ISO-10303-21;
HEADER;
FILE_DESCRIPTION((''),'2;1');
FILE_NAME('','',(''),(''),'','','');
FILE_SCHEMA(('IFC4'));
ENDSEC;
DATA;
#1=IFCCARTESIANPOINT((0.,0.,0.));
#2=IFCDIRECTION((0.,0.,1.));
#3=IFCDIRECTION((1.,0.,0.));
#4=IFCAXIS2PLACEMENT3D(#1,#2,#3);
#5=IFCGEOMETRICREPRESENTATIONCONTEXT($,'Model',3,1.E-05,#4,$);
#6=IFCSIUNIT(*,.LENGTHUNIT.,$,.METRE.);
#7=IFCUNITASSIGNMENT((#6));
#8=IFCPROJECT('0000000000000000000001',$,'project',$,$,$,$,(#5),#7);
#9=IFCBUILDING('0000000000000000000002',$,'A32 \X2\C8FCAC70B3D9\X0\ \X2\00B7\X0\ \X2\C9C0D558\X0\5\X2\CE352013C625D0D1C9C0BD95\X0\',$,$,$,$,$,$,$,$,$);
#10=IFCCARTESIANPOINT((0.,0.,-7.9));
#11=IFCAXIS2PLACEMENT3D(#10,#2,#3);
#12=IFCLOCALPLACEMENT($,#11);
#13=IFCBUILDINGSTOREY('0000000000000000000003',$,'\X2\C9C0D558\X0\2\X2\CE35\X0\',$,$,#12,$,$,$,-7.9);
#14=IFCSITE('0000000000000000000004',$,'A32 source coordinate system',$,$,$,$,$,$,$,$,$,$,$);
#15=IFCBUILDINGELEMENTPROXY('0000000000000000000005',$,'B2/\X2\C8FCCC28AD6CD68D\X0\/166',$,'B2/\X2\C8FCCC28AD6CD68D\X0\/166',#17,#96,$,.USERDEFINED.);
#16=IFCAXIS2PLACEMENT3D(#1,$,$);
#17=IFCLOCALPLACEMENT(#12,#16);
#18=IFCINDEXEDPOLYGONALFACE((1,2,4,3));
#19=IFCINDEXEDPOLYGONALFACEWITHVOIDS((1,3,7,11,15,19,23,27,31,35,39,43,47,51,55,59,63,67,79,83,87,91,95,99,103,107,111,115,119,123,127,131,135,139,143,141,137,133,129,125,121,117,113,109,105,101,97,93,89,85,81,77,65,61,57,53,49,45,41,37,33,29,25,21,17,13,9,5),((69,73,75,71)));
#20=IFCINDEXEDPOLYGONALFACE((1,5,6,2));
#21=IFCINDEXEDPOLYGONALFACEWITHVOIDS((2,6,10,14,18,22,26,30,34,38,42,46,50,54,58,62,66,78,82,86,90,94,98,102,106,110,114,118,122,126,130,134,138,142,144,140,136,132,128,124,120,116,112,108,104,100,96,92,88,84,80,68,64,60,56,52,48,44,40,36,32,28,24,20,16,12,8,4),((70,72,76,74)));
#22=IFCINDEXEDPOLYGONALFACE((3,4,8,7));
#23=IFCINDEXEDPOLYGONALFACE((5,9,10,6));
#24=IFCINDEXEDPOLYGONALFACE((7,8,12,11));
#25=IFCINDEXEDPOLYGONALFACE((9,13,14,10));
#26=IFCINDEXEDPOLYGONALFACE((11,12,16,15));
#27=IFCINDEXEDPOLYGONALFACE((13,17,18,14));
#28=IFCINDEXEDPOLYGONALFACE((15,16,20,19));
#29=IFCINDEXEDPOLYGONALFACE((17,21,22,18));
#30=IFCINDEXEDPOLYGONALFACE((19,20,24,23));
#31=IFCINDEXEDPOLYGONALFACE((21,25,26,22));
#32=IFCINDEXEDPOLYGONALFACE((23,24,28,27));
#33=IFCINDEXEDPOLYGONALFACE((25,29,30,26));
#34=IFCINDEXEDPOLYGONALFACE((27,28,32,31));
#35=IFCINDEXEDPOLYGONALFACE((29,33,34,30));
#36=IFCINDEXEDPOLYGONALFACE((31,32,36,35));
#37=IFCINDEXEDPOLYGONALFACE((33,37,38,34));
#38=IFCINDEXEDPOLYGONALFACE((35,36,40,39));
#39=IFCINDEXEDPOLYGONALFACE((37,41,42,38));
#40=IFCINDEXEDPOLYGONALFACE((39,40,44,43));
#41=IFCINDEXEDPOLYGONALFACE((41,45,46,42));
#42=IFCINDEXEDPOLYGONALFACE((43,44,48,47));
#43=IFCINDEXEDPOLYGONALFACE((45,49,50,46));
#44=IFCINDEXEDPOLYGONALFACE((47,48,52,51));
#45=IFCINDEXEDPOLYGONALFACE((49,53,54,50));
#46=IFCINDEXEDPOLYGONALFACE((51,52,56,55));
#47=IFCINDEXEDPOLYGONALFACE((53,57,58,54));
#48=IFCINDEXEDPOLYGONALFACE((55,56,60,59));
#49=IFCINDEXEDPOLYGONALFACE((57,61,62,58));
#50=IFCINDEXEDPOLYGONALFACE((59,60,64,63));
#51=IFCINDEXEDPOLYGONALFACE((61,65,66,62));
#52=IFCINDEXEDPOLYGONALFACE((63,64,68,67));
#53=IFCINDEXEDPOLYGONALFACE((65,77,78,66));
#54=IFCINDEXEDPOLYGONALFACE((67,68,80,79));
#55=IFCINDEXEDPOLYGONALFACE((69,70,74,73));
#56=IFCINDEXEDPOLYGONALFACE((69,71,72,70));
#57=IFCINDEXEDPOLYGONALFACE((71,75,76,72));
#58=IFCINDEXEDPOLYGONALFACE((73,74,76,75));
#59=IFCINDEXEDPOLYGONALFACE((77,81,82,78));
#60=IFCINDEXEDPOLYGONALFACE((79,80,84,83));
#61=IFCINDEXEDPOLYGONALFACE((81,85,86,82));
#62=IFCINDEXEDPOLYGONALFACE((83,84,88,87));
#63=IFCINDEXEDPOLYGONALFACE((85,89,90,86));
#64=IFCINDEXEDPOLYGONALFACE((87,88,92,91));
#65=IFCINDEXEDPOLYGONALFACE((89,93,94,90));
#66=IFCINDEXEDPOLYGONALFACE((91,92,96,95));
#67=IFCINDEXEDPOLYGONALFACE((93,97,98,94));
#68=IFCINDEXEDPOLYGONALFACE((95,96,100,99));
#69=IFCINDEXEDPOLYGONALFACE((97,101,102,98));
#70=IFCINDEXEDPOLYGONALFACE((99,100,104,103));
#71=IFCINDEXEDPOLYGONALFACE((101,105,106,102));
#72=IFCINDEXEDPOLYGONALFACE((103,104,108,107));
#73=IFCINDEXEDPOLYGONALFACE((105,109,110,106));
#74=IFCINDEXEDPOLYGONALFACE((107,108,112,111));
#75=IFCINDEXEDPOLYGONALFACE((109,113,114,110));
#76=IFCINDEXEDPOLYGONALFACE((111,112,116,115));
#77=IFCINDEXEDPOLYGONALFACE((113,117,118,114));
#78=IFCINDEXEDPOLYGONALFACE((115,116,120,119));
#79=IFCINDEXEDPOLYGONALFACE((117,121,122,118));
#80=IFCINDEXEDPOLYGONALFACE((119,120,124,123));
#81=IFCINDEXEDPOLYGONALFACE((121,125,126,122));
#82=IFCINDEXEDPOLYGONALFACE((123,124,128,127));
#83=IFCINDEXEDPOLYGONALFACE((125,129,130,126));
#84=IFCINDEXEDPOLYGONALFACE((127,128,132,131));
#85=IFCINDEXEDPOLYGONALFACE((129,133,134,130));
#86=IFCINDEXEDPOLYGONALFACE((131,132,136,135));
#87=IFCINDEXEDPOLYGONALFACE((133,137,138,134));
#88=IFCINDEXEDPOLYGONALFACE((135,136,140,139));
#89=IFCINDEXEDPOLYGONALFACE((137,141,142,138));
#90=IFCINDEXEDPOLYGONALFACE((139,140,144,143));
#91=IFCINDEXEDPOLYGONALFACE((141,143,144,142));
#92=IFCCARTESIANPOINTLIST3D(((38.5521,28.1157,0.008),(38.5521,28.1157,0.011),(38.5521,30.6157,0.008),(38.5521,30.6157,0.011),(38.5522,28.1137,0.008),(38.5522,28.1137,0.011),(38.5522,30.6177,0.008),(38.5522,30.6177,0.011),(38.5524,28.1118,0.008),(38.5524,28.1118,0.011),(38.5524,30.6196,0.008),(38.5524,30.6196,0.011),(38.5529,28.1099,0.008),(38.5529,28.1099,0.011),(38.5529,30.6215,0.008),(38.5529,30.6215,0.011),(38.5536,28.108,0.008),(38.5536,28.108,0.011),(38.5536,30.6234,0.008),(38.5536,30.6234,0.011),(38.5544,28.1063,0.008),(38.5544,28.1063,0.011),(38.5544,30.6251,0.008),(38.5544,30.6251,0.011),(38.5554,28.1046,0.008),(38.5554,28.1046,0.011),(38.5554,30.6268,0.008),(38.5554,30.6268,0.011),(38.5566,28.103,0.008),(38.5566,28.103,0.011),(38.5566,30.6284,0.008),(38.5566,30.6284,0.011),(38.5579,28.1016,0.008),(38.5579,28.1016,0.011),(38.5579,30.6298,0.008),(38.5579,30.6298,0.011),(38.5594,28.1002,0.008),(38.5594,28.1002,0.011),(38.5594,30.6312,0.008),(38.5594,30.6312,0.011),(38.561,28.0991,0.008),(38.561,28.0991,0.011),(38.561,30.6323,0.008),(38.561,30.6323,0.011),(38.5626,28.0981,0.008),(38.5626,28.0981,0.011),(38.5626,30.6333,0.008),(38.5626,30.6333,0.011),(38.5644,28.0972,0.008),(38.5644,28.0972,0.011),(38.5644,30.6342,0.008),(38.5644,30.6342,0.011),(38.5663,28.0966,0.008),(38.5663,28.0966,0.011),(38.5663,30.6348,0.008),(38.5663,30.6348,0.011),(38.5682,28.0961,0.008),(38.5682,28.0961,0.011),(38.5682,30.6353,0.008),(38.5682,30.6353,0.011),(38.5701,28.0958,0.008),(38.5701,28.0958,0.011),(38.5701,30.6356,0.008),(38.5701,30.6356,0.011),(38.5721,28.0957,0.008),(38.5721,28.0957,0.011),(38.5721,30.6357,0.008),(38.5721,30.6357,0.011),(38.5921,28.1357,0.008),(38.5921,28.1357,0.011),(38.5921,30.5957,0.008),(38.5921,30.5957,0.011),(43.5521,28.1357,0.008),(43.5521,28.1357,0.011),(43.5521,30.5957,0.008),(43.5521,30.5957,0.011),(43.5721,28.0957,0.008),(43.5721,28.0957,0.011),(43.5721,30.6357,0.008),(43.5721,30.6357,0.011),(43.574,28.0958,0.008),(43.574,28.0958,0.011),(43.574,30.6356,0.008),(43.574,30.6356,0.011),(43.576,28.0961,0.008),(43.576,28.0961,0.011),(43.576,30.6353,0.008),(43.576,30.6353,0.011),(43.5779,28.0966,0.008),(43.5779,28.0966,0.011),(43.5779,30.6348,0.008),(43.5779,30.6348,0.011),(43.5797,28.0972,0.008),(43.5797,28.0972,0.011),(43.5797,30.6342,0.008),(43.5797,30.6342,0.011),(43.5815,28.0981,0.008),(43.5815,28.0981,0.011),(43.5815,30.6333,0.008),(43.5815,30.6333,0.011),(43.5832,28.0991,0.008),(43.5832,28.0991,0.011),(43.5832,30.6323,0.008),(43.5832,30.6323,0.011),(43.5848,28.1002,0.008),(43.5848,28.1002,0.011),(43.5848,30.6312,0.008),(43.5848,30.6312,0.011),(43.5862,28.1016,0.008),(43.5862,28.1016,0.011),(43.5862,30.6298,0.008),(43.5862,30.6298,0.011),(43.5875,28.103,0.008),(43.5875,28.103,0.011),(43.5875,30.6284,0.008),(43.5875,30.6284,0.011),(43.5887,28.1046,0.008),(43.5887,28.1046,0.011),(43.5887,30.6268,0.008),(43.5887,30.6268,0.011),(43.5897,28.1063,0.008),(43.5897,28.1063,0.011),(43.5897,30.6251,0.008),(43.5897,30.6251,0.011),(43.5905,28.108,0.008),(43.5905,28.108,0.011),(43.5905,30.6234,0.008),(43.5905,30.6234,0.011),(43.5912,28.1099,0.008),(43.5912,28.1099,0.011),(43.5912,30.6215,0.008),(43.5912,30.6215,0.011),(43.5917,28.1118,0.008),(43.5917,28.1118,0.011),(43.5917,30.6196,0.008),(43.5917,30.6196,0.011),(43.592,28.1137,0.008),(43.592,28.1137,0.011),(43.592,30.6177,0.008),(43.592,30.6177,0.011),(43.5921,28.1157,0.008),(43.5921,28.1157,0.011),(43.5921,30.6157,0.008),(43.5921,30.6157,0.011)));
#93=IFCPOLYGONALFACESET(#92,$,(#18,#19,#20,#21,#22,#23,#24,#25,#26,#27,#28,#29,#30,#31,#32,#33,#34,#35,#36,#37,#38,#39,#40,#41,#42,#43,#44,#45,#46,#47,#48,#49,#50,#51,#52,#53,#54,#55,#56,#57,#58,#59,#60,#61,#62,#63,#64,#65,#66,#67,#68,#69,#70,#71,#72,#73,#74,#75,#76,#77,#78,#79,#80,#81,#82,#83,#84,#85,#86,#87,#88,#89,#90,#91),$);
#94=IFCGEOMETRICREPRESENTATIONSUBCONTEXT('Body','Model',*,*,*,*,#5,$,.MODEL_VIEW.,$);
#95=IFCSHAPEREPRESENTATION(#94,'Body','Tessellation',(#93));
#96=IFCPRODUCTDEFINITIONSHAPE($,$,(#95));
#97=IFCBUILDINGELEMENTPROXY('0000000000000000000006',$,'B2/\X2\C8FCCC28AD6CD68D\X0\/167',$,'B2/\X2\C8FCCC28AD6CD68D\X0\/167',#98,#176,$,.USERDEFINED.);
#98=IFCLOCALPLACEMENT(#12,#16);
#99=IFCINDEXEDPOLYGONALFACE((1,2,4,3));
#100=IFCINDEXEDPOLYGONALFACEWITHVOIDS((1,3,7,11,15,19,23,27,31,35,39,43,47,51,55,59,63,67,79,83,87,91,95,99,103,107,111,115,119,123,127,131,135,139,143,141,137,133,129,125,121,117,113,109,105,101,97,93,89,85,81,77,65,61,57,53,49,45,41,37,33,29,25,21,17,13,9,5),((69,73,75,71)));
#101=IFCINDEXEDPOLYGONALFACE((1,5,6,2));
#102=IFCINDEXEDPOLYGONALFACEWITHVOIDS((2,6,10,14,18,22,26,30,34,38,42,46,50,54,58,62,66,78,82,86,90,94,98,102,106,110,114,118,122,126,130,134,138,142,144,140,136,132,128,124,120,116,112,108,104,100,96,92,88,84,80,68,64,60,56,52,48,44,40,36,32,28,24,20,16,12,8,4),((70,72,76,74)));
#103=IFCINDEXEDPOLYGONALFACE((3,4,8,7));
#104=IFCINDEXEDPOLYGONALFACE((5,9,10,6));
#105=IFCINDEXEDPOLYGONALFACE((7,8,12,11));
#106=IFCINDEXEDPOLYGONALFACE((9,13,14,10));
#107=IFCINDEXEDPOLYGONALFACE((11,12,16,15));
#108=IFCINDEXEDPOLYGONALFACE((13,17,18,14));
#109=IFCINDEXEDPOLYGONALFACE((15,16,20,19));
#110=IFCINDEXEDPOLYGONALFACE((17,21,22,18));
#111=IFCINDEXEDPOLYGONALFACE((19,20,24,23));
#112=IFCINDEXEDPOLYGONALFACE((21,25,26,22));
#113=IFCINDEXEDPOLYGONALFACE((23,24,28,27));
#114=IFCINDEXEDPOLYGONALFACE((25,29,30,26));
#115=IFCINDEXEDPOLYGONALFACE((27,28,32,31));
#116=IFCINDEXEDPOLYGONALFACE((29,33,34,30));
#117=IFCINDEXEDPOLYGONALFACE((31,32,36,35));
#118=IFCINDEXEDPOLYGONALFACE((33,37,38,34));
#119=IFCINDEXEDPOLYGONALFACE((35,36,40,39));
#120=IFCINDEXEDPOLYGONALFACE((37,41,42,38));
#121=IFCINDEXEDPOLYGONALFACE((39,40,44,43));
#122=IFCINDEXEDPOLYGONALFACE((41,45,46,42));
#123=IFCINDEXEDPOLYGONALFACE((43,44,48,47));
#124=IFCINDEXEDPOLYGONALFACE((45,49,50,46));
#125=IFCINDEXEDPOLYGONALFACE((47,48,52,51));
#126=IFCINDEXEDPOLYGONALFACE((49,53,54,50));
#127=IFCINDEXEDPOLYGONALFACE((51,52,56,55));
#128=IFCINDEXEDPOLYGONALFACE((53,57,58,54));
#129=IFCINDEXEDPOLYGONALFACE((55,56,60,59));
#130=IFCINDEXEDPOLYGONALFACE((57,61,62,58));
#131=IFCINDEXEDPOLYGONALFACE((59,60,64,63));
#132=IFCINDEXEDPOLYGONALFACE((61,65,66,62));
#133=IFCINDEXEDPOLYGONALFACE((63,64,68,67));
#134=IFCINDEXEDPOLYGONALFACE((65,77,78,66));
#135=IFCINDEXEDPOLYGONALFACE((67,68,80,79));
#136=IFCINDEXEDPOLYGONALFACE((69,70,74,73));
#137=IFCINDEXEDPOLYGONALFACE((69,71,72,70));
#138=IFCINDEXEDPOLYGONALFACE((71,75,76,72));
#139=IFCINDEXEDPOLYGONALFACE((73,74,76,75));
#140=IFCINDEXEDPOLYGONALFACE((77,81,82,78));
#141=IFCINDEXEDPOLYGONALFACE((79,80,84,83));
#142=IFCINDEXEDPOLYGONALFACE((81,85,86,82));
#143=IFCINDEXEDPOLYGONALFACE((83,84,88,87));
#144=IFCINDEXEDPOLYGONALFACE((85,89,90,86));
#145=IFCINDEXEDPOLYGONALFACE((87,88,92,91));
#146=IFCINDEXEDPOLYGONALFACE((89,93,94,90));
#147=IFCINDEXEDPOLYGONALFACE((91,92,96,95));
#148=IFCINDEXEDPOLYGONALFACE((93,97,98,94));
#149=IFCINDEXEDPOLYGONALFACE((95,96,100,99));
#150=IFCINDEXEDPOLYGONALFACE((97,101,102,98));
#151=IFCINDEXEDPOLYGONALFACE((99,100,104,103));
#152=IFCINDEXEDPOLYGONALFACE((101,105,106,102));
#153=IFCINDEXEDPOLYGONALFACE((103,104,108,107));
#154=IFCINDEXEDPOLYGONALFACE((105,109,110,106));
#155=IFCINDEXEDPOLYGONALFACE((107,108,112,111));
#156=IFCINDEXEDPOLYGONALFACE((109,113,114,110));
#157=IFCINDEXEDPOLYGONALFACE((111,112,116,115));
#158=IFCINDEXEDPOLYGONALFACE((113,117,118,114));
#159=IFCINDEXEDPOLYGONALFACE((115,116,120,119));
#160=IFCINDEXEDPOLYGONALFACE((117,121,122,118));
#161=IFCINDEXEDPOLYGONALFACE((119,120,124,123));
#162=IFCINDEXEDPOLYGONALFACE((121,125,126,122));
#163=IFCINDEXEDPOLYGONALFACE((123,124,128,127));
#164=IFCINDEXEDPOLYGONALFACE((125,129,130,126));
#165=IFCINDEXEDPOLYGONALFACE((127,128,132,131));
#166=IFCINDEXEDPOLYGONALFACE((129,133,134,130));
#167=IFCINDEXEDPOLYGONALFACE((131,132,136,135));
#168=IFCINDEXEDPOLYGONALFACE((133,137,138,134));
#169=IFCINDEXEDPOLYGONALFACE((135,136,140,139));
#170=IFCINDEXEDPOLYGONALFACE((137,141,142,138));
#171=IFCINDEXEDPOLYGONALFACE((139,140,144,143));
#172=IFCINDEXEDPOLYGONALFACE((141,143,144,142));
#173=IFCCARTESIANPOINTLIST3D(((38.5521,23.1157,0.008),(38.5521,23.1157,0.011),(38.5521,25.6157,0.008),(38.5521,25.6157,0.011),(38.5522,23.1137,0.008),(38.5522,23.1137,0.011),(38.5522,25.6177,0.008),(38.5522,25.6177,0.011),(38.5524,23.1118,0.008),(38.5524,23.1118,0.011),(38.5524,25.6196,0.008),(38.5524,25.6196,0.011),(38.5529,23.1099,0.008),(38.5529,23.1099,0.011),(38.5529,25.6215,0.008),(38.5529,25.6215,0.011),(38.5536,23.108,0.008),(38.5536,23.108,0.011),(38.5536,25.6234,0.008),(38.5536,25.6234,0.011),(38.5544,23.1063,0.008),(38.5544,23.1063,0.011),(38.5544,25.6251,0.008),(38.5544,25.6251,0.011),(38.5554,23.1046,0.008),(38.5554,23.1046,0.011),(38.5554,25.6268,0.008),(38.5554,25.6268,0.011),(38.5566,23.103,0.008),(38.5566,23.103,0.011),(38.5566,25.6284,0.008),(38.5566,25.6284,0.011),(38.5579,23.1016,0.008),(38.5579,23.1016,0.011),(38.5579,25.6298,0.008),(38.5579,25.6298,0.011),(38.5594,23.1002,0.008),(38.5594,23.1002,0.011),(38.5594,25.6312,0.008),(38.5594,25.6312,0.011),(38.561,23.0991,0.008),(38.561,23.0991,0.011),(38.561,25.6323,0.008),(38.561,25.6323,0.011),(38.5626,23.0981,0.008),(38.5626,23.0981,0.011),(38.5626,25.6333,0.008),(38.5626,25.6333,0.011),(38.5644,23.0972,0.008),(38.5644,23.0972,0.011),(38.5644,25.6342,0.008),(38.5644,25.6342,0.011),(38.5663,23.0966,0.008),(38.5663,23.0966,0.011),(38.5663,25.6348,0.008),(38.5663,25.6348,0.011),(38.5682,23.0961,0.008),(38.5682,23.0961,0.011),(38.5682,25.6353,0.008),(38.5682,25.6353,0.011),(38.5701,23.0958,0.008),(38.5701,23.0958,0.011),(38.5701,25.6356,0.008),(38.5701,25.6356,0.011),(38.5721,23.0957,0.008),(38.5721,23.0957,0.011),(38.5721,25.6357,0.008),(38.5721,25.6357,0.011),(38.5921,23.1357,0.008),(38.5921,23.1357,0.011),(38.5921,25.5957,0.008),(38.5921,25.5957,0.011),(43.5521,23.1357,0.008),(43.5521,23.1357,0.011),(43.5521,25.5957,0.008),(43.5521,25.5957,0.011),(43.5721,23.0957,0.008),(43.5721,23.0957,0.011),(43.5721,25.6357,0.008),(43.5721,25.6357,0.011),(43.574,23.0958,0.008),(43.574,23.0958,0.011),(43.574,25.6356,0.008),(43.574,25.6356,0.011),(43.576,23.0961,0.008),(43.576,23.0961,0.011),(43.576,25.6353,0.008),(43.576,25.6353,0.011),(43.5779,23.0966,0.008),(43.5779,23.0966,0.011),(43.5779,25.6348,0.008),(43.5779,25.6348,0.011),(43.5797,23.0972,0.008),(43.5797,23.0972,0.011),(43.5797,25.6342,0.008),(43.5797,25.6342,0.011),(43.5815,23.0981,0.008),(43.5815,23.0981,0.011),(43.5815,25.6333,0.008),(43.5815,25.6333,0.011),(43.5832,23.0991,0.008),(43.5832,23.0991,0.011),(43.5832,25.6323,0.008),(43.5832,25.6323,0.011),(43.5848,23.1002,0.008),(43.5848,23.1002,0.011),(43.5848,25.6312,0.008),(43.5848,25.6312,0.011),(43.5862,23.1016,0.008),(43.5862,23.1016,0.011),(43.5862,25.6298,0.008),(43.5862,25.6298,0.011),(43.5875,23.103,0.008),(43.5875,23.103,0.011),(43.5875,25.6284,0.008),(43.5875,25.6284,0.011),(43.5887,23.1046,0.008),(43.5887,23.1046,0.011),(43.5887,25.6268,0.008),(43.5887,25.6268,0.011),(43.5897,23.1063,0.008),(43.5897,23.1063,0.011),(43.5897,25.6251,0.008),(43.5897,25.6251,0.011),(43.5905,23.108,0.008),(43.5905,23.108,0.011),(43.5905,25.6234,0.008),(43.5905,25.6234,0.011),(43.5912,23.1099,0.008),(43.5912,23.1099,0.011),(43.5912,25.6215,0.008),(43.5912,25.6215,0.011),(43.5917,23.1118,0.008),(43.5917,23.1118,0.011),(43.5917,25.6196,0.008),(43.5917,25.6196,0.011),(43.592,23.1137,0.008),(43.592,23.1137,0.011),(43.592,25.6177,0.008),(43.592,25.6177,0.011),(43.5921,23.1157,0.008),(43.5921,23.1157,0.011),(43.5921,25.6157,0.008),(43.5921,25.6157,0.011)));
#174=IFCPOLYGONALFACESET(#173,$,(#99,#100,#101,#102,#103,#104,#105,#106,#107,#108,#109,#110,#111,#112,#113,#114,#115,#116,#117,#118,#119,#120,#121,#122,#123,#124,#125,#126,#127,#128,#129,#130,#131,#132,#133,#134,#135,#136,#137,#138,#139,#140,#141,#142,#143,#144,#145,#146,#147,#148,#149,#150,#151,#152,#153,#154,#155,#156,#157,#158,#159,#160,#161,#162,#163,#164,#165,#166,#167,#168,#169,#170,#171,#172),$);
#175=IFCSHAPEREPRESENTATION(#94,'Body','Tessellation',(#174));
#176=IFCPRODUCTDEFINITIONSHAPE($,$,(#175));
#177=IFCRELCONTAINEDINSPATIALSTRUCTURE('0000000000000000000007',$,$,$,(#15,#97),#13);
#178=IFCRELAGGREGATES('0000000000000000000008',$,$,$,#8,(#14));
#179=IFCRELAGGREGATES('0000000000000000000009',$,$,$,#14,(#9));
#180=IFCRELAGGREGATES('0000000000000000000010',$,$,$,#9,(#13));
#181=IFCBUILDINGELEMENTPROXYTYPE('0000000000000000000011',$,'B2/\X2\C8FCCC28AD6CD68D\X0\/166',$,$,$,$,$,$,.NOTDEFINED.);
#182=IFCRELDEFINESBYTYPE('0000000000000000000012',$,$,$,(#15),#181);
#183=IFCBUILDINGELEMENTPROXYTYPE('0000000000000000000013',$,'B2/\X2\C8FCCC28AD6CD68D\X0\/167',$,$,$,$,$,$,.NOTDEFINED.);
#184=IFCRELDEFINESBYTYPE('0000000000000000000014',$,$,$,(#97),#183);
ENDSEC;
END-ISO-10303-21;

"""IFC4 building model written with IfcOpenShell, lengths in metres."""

from ifc_helpers import new_model, si_unit, frame, origin, origin_with_axes, place, context, subcontext, project, spatial, polyline, outline, extrude, source, transform, mapped, type_object, type_shapes, element, save


model = new_model("IFC4")

# Units and contexts
model_context = context("Model", 3, precision=1e-05, world=origin_with_axes())
body_context = subcontext(model_context, "Body", "Model", "MODEL_VIEW")
ifc_project = project(units=[si_unit("LENGTHUNIT", "METRE")], contexts=[model_context])

# Site, building, storey
site = spatial("IfcSite", under=ifc_project, Name="A32 source coordinate system")
building = spatial("IfcBuilding", under=site, Name="A32 주거동 · 지하5층–옥탑지붕")
storey_placement = place(None, frame((0.0, 0.0, -7.9), z_axis=(0.0, 0.0, 1.0), x_axis=(1.0, 0.0, 0.0)))
storey = spatial("IfcBuildingStorey", under=building, at=storey_placement, Name="지하2층", Elevation=-7.9)

# Building element proxies
building_element_proxy_type_1 = type_object("IfcBuildingElementProxyType", Name="B2/주차구획/166", PredefinedType="NOTDEFINED")
shared_shape_1 = source(origin(), body_context, "Body", "SweptSolid", [
    extrude(outline(polyline([(43.5721, 30.6357), (43.574, 30.6356), (43.576, 30.6353), (43.5779, 30.6348), (43.5797, 30.6342), (43.5815, 30.6333), (43.5832, 30.6323), (43.5848, 30.6312), (43.5862, 30.6298), (43.5875, 30.6284), (43.5887, 30.6268), (43.5897, 30.6251), (43.5905, 30.6234), (43.5912, 30.6215), (43.5917, 30.6196), (43.592, 30.6177), (43.5921, 30.6157), (43.5921, 28.1157), (43.592, 28.1137), (43.5917, 28.1118), (43.5912, 28.1099), (43.5905, 28.108), (43.5897, 28.1063), (43.5887, 28.1046), (43.5875, 28.103), (43.5862, 28.1016), (43.5848, 28.1002), (43.5832, 28.0991), (43.5815, 28.0981), (43.5797, 28.0972), (43.5779, 28.0966), (43.576, 28.0961), (43.574, 28.0958), (43.5721, 28.0957), (38.5721, 28.0957), (38.5701, 28.0958), (38.5682, 28.0961), (38.5663, 28.0966), (38.5644, 28.0972), (38.5626, 28.0981), (38.561, 28.0991), (38.5594, 28.1002), (38.5579, 28.1016), (38.5566, 28.103), (38.5554, 28.1046), (38.5544, 28.1063), (38.5536, 28.108), (38.5529, 28.1099), (38.5524, 28.1118), (38.5522, 28.1137), (38.5521, 28.1157), (38.5521, 30.6157), (38.5522, 30.6177), (38.5524, 30.6196), (38.5529, 30.6215), (38.5536, 30.6234), (38.5544, 30.6251), (38.5554, 30.6268), (38.5566, 30.6284), (38.5579, 30.6298), (38.5594, 30.6312), (38.561, 30.6323), (38.5626, 30.6333), (38.5644, 30.6342), (38.5663, 30.6348), (38.5682, 30.6353), (38.5701, 30.6356), (38.5721, 30.6357), (43.5721, 30.6357)]), holes=[polyline([(43.5521, 30.5957), (38.5921, 30.5957), (38.5921, 28.1357), (43.5521, 28.1357), (43.5521, 30.5957)])]), frame((0.0, 0.0, 0.008)), (0.0, 0.0, 1.0), 0.003),
])
type_shapes(building_element_proxy_type_1, [shared_shape_1])
proxy_1_placement = place(storey_placement, origin_with_axes())
element("IfcBuildingElementProxy", 1, at=proxy_1_placement, inside=storey, type_object=building_element_proxy_type_1, Name="B2/주차구획/166", ObjectType="B2/주차구획/166", PredefinedType="USERDEFINED", context=body_context, shape_type="MappedRepresentation", body=[
    mapped(shared_shape_1, transform((0.0, 0.0, 0.0), scale=1.0)),
])
building_element_proxy_type_2 = type_object("IfcBuildingElementProxyType", Name="B2/주차구획/167", PredefinedType="NOTDEFINED")
shared_shape_2 = source(origin(), body_context, "Body", "SweptSolid", [
    extrude(outline(polyline([(43.5721, 25.6357), (43.574, 25.6356), (43.576, 25.6353), (43.5779, 25.6348), (43.5797, 25.6342), (43.5815, 25.6333), (43.5832, 25.6323), (43.5848, 25.6312), (43.5862, 25.6298), (43.5875, 25.6284), (43.5887, 25.6268), (43.5897, 25.6251), (43.5905, 25.6234), (43.5912, 25.6215), (43.5917, 25.6196), (43.592, 25.6177), (43.5921, 25.6157), (43.5921, 23.1157), (43.592, 23.1137), (43.5917, 23.1118), (43.5912, 23.1099), (43.5905, 23.108), (43.5897, 23.1063), (43.5887, 23.1046), (43.5875, 23.103), (43.5862, 23.1016), (43.5848, 23.1002), (43.5832, 23.0991), (43.5815, 23.0981), (43.5797, 23.0972), (43.5779, 23.0966), (43.576, 23.0961), (43.574, 23.0958), (43.5721, 23.0957), (38.5721, 23.0957), (38.5701, 23.0958), (38.5682, 23.0961), (38.5663, 23.0966), (38.5644, 23.0972), (38.5626, 23.0981), (38.561, 23.0991), (38.5594, 23.1002), (38.5579, 23.1016), (38.5566, 23.103), (38.5554, 23.1046), (38.5544, 23.1063), (38.5536, 23.108), (38.5529, 23.1099), (38.5524, 23.1118), (38.5522, 23.1137), (38.5521, 23.1157), (38.5521, 25.6157), (38.5522, 25.6177), (38.5524, 25.6196), (38.5529, 25.6215), (38.5536, 25.6234), (38.5544, 25.6251), (38.5554, 25.6268), (38.5566, 25.6284), (38.5579, 25.6298), (38.5594, 25.6312), (38.561, 25.6323), (38.5626, 25.6333), (38.5644, 25.6342), (38.5663, 25.6348), (38.5682, 25.6353), (38.5701, 25.6356), (38.5721, 25.6357), (43.5721, 25.6357)]), holes=[polyline([(43.5521, 25.5957), (38.5921, 25.5957), (38.5921, 23.1357), (43.5521, 23.1357), (43.5521, 25.5957)])]), frame((0.0, 0.0, 0.008)), (0.0, 0.0, 1.0), 0.003),
])
type_shapes(building_element_proxy_type_2, [shared_shape_2])
proxy_2_placement = place(storey_placement, origin_with_axes())
element("IfcBuildingElementProxy", 2, at=proxy_2_placement, inside=storey, type_object=building_element_proxy_type_2, Name="B2/주차구획/167", ObjectType="B2/주차구획/167", PredefinedType="USERDEFINED", context=body_context, shape_type="MappedRepresentation", body=[
    mapped(shared_shape_2, transform((0.0, 0.0, 0.0), scale=1.0)),
])

save(model, "model.ifc")
